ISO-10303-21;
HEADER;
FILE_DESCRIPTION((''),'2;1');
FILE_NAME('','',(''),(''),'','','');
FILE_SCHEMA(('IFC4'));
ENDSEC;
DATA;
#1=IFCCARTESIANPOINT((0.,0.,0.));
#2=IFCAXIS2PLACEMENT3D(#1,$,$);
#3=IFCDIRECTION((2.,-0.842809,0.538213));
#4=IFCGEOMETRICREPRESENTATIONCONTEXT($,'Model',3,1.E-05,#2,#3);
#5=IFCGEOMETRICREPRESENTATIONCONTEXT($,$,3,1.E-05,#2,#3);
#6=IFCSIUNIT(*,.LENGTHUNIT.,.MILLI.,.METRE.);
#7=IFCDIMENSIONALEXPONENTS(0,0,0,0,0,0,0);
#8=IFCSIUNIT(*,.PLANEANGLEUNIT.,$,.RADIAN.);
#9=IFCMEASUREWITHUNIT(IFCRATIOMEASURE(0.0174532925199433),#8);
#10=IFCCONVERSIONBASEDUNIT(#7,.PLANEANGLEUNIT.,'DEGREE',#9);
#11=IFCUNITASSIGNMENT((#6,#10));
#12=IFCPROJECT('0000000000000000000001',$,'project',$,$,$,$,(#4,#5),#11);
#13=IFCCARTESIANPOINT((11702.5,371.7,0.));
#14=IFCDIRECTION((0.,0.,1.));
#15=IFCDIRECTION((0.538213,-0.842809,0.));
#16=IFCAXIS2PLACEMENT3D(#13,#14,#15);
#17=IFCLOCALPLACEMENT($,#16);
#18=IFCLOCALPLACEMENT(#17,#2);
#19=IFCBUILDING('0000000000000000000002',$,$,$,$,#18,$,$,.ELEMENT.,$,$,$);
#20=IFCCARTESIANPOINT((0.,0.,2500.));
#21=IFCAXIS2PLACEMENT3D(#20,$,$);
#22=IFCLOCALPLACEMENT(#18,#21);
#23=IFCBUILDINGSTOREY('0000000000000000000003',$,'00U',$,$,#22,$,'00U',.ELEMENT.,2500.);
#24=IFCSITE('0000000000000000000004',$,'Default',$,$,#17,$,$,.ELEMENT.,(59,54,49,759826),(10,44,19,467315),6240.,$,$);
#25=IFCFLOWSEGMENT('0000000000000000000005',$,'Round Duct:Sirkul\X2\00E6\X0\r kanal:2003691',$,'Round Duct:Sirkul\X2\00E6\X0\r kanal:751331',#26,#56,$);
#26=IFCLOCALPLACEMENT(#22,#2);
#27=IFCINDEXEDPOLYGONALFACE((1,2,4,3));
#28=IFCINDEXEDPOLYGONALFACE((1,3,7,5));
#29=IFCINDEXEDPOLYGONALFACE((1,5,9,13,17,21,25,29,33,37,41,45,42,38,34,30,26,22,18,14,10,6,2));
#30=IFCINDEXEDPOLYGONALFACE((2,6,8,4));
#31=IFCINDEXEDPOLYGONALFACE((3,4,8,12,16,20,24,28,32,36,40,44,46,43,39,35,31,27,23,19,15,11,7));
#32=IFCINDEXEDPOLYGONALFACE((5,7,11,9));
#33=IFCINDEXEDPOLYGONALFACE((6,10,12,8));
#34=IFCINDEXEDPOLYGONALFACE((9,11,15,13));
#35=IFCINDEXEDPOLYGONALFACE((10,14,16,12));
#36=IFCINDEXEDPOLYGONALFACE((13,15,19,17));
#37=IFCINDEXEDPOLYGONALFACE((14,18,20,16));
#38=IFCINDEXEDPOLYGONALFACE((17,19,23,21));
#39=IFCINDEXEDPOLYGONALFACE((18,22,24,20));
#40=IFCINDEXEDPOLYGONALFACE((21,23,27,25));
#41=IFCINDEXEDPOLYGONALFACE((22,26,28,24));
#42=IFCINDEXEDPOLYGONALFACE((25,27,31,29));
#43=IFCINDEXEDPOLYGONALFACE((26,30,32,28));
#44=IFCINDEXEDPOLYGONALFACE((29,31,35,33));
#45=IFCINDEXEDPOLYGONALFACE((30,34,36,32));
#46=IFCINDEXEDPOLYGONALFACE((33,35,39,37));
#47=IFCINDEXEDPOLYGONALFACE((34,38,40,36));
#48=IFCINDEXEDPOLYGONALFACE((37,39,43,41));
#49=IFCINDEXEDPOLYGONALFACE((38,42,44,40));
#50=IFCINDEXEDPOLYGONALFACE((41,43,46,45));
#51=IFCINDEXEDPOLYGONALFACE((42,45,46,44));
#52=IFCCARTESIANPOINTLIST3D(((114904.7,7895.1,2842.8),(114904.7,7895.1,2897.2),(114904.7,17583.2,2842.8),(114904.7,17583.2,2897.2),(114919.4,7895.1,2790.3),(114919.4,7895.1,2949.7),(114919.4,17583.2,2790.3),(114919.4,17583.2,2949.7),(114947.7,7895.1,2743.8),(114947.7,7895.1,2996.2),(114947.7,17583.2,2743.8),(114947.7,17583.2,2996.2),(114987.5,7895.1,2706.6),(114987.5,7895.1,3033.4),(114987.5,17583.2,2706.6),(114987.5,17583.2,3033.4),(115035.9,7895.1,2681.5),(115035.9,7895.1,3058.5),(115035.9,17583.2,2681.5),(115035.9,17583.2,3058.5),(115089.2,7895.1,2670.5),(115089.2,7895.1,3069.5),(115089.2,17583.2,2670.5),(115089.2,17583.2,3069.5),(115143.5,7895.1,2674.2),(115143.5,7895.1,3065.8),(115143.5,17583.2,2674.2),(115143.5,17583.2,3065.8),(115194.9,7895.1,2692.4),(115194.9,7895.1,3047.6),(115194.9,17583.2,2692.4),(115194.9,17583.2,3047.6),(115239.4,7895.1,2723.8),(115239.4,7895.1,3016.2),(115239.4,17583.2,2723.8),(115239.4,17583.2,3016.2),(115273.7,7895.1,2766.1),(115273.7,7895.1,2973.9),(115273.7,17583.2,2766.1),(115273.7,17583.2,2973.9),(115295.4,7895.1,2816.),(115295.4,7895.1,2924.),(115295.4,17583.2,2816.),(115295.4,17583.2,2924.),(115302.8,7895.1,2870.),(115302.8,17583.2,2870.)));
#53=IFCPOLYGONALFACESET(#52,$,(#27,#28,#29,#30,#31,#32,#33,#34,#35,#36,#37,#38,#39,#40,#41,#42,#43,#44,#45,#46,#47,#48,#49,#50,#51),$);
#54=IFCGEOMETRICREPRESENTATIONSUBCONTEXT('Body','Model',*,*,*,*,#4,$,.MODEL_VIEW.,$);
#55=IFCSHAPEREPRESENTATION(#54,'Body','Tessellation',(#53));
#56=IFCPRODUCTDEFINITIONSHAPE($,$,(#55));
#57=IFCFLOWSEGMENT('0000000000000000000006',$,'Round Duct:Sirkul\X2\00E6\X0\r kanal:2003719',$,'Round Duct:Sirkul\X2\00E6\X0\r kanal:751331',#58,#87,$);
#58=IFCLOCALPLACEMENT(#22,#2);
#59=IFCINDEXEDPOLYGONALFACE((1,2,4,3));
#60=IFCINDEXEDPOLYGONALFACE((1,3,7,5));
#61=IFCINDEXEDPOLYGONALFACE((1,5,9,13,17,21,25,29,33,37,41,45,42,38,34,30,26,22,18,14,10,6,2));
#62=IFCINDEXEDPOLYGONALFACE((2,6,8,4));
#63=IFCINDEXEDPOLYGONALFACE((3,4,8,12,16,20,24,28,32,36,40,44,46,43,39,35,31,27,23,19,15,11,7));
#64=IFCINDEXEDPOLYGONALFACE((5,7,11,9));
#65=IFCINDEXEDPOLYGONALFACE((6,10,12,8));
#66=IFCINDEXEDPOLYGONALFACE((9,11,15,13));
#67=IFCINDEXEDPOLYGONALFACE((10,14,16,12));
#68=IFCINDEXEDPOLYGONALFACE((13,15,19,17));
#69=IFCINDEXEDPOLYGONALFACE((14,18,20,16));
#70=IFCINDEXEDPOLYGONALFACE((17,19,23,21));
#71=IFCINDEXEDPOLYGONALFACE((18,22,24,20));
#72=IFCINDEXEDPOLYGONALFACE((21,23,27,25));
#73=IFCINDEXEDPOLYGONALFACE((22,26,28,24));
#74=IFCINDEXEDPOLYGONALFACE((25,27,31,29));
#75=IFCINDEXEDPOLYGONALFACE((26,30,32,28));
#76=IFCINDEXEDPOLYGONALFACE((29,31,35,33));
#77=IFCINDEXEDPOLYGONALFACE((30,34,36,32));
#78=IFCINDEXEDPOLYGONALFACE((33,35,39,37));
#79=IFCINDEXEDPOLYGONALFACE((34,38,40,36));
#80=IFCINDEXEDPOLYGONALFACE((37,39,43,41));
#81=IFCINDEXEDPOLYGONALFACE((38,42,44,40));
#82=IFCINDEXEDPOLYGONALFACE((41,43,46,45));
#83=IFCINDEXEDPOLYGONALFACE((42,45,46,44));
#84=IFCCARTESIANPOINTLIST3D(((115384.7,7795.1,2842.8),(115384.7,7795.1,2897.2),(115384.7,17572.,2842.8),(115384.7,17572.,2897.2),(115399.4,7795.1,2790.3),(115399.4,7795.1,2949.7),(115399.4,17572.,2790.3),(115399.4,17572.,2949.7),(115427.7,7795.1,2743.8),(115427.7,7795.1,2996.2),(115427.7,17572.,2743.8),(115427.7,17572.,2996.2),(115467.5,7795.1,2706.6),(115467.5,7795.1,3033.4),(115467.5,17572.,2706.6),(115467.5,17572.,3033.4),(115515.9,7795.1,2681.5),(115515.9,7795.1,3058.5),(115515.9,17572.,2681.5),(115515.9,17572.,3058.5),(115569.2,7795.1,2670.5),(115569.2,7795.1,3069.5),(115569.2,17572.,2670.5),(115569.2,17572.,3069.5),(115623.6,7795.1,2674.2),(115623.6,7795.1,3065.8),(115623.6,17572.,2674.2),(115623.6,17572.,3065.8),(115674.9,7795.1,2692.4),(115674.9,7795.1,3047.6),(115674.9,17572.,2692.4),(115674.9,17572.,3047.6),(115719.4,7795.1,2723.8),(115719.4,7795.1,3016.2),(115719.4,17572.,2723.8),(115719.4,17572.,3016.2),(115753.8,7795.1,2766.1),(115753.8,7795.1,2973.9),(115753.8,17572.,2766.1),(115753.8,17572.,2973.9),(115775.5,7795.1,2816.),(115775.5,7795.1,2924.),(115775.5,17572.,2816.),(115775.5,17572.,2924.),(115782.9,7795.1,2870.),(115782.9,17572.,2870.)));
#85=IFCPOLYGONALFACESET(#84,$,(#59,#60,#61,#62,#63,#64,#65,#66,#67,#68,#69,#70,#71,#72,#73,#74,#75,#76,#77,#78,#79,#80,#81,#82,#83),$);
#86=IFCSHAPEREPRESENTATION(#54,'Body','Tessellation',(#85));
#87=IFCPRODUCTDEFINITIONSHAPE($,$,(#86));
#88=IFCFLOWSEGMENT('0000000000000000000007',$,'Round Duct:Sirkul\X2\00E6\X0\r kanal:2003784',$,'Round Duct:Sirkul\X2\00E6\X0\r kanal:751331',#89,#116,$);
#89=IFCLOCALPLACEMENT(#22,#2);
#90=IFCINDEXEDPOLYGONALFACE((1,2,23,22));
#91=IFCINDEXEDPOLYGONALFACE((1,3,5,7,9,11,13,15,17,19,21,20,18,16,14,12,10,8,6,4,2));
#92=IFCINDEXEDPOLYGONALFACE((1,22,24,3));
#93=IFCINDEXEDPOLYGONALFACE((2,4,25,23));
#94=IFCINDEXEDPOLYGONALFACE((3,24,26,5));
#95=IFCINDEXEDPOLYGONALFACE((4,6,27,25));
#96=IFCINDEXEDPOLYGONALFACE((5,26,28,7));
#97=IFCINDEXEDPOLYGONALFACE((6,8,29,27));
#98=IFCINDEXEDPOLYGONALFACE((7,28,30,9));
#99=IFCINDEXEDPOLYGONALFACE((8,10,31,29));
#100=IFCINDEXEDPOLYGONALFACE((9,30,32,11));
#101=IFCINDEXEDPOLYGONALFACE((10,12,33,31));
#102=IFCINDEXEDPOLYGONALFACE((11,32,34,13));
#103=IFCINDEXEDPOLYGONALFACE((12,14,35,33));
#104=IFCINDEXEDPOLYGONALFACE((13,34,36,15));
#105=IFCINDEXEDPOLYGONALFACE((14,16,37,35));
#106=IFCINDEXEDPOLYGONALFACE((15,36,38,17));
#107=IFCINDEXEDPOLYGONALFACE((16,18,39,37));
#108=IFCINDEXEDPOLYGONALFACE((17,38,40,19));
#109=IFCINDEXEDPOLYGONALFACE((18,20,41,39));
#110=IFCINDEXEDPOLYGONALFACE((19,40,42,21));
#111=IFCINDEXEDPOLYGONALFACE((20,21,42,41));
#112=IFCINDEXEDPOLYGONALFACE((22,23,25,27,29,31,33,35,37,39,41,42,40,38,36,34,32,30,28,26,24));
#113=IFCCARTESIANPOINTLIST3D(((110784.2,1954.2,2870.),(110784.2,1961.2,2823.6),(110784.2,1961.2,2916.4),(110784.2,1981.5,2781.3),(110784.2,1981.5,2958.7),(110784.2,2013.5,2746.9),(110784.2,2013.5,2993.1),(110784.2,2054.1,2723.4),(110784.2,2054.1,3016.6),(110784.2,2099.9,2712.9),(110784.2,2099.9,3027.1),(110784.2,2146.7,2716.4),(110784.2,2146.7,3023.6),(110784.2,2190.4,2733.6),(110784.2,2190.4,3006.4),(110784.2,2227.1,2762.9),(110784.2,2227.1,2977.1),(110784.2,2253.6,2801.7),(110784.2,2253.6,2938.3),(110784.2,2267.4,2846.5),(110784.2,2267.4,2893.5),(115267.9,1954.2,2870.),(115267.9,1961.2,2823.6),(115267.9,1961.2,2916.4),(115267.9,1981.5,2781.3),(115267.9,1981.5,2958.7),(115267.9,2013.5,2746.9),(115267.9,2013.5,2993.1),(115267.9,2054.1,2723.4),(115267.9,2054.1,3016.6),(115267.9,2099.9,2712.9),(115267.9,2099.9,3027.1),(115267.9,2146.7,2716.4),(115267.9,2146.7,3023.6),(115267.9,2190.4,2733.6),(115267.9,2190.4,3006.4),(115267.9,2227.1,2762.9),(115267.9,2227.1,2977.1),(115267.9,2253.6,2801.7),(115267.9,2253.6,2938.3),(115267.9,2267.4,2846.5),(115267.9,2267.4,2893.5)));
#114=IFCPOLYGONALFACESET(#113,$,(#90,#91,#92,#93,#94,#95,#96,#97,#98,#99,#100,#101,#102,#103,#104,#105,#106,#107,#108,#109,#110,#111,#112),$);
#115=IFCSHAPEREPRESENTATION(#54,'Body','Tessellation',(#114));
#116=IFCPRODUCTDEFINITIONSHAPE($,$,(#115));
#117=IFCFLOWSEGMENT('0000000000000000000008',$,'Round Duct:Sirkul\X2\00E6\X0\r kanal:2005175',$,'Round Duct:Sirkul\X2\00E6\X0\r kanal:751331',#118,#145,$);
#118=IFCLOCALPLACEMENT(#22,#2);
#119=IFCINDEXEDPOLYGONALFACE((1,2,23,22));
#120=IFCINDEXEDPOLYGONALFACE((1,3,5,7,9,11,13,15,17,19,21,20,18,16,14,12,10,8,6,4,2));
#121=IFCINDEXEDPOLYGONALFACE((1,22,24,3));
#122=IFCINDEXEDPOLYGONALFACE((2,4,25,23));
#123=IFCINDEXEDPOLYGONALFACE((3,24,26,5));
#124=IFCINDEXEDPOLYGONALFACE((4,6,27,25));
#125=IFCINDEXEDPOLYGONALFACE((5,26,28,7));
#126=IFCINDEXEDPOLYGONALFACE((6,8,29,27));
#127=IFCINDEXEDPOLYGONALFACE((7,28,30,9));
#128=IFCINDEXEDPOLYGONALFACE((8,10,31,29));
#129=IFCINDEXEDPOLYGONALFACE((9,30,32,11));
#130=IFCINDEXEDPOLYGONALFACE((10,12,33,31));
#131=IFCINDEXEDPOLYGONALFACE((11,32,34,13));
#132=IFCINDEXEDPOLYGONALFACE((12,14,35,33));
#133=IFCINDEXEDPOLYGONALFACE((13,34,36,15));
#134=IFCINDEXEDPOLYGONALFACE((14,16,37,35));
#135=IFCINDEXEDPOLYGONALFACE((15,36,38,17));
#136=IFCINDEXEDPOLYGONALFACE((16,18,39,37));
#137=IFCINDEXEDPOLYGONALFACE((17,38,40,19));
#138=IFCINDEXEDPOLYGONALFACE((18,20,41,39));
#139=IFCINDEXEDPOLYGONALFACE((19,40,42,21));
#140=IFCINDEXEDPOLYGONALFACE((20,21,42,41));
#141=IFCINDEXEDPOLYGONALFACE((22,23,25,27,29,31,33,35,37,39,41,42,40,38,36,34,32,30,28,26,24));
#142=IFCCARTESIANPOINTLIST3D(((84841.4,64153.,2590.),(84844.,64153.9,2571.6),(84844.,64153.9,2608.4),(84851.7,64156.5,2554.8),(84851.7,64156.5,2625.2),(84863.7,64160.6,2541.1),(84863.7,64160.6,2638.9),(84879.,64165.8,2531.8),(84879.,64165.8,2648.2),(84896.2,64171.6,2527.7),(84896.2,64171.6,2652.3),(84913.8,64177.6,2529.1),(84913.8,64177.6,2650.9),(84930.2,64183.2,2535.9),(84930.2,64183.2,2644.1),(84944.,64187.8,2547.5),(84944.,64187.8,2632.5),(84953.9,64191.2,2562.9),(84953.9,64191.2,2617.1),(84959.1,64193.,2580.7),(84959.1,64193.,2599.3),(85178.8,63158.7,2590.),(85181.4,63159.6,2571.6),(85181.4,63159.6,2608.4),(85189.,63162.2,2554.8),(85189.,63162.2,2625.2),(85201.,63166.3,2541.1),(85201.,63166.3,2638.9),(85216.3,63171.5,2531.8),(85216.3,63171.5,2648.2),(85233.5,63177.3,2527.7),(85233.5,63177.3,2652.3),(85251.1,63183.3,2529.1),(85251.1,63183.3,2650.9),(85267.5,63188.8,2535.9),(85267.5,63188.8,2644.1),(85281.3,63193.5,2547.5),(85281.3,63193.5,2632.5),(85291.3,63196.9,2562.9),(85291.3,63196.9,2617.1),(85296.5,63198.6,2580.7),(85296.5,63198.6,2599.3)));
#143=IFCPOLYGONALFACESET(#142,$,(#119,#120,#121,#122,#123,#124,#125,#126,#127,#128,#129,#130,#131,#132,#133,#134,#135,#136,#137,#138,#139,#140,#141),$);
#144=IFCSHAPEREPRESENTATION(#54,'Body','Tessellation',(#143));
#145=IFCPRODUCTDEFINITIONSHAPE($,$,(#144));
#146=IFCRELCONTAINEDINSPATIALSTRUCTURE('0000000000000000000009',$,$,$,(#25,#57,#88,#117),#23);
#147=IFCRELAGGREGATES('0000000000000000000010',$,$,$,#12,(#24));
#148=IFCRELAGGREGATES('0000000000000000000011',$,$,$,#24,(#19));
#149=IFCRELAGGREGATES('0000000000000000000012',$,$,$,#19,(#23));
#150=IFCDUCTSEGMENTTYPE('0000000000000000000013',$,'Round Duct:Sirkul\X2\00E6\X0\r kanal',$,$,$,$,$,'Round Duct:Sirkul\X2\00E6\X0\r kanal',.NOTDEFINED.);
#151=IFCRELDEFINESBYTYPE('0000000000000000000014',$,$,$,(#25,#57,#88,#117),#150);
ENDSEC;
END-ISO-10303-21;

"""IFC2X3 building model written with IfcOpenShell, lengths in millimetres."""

from ifc_helpers import new_model, entity, si_unit, converted_unit, direction, frame, frame_2d, origin, origin_2d_with_axis, place, context, subcontext, project, spatial, circle, extrude, type_object, element, save


model = new_model("IFC2X3")

# Units and contexts
model_context = context("Model", 3, precision=1e-05, world=origin(), true_north=direction((2.0, -0.842809, 0.538213)))
context_of_model = context(None, 3, precision=1e-05, world=origin(), true_north=direction((2.0, -0.842809, 0.538213)))
body_context = subcontext(model_context, "Body", "Model", "MODEL_VIEW")
ifc_project = project(units=[si_unit("LENGTHUNIT", "METRE", prefix="MILLI"), converted_unit("PLANEANGLEUNIT", "DEGREE", entity("IfcRatioMeasure", 0.0174532925199433), si_unit("PLANEANGLEUNIT", "RADIAN"), dimensions=[0, 0, 0, 0, 0, 0, 0])], contexts=[model_context, context_of_model])

# Site, building, storey
site_placement = place(None, frame((11702.5, 371.7, 0.0), z_axis=(0.0, 0.0, 1.0), x_axis=(0.538213, -0.842809, 0.0)))
site = spatial("IfcSite", under=ifc_project, at=site_placement, Name="Default", CompositionType="ELEMENT", RefLatitude=(59, 54, 49, 759826), RefLongitude=(10, 44, 19, 467315), RefElevation=6240.0)
building_placement = place(site_placement, origin())
building = spatial("IfcBuilding", under=site, at=building_placement, CompositionType="ELEMENT")
storey_placement = place(building_placement, frame((0.0, 0.0, 2500.0)))
storey = spatial("IfcBuildingStorey", under=building, at=storey_placement, Name="00U", LongName="00U", CompositionType="ELEMENT", Elevation=2500.0)

# Flow segments
duct_segment_type_1 = type_object("IfcDuctSegmentType", Name="Round Duct:Sirkulær kanal", ElementType="Round Duct:Sirkulær kanal", PredefinedType="NOTDEFINED")
flow_segment_1_placement = place(storey_placement, origin())
element("IfcFlowSegment", 1, at=flow_segment_1_placement, inside=storey, type_object=duct_segment_type_1, Name="Round Duct:Sirkulær kanal:2003691", ObjectType="Round Duct:Sirkulær kanal:751331", context=body_context, shape_type="SweptSolid", body=[
    extrude(circle(Radius=200.0, at=origin_2d_with_axis()), frame((115102.8, 7895.1, 2870.0), z_axis=(0.0, 1.0, 0.0), x_axis=(1.0, 0.0, 0.0)), (0.0, 0.0, 1.0), 9688.1),
])
flow_segment_2_placement = place(storey_placement, origin())
element("IfcFlowSegment", 2, at=flow_segment_2_placement, inside=storey, type_object=duct_segment_type_1, Name="Round Duct:Sirkulær kanal:2003719", ObjectType="Round Duct:Sirkulær kanal:751331", context=body_context, shape_type="SweptSolid", body=[
    extrude(circle(Radius=200.0, at=origin_2d_with_axis()), frame((115582.9, 7795.1, 2870.0), z_axis=(0.0, 1.0, 0.0), x_axis=(1.0, 0.0, 0.0)), (0.0, 0.0, 1.0), 9776.9),
])
flow_segment_3_placement = place(storey_placement, origin())
element("IfcFlowSegment", 3, at=flow_segment_3_placement, inside=storey, type_object=duct_segment_type_1, Name="Round Duct:Sirkulær kanal:2003784", ObjectType="Round Duct:Sirkulær kanal:751331", context=body_context, shape_type="SweptSolid", body=[
    extrude(circle(Radius=157.5, at=frame_2d((0.0, 0.0), x_axis=(1.0, 0.0))), frame((110784.2, 2111.7, 2870.0), z_axis=(1.0, 0.0, 0.0), x_axis=(0.0, -1.0, 0.0)), (0.0, 0.0, 1.0), 4483.7),
])
flow_segment_4_placement = place(storey_placement, origin())
element("IfcFlowSegment", 4, at=flow_segment_4_placement, inside=storey, type_object=duct_segment_type_1, Name="Round Duct:Sirkulær kanal:2005175", ObjectType="Round Duct:Sirkulær kanal:751331", context=body_context, shape_type="SweptSolid", body=[
    extrude(circle(Radius=62.5, at=frame_2d((0.0, 0.0), x_axis=(1.0, 0.0))), frame((84900.6, 64173.1, 2590.0), z_axis=(0.321289, -0.946981, 0.0), x_axis=(-0.946981, -0.321289, 0.0)), (0.0, 0.0, 1.0), 1050.0),
])

save(model, "model.ifc")
